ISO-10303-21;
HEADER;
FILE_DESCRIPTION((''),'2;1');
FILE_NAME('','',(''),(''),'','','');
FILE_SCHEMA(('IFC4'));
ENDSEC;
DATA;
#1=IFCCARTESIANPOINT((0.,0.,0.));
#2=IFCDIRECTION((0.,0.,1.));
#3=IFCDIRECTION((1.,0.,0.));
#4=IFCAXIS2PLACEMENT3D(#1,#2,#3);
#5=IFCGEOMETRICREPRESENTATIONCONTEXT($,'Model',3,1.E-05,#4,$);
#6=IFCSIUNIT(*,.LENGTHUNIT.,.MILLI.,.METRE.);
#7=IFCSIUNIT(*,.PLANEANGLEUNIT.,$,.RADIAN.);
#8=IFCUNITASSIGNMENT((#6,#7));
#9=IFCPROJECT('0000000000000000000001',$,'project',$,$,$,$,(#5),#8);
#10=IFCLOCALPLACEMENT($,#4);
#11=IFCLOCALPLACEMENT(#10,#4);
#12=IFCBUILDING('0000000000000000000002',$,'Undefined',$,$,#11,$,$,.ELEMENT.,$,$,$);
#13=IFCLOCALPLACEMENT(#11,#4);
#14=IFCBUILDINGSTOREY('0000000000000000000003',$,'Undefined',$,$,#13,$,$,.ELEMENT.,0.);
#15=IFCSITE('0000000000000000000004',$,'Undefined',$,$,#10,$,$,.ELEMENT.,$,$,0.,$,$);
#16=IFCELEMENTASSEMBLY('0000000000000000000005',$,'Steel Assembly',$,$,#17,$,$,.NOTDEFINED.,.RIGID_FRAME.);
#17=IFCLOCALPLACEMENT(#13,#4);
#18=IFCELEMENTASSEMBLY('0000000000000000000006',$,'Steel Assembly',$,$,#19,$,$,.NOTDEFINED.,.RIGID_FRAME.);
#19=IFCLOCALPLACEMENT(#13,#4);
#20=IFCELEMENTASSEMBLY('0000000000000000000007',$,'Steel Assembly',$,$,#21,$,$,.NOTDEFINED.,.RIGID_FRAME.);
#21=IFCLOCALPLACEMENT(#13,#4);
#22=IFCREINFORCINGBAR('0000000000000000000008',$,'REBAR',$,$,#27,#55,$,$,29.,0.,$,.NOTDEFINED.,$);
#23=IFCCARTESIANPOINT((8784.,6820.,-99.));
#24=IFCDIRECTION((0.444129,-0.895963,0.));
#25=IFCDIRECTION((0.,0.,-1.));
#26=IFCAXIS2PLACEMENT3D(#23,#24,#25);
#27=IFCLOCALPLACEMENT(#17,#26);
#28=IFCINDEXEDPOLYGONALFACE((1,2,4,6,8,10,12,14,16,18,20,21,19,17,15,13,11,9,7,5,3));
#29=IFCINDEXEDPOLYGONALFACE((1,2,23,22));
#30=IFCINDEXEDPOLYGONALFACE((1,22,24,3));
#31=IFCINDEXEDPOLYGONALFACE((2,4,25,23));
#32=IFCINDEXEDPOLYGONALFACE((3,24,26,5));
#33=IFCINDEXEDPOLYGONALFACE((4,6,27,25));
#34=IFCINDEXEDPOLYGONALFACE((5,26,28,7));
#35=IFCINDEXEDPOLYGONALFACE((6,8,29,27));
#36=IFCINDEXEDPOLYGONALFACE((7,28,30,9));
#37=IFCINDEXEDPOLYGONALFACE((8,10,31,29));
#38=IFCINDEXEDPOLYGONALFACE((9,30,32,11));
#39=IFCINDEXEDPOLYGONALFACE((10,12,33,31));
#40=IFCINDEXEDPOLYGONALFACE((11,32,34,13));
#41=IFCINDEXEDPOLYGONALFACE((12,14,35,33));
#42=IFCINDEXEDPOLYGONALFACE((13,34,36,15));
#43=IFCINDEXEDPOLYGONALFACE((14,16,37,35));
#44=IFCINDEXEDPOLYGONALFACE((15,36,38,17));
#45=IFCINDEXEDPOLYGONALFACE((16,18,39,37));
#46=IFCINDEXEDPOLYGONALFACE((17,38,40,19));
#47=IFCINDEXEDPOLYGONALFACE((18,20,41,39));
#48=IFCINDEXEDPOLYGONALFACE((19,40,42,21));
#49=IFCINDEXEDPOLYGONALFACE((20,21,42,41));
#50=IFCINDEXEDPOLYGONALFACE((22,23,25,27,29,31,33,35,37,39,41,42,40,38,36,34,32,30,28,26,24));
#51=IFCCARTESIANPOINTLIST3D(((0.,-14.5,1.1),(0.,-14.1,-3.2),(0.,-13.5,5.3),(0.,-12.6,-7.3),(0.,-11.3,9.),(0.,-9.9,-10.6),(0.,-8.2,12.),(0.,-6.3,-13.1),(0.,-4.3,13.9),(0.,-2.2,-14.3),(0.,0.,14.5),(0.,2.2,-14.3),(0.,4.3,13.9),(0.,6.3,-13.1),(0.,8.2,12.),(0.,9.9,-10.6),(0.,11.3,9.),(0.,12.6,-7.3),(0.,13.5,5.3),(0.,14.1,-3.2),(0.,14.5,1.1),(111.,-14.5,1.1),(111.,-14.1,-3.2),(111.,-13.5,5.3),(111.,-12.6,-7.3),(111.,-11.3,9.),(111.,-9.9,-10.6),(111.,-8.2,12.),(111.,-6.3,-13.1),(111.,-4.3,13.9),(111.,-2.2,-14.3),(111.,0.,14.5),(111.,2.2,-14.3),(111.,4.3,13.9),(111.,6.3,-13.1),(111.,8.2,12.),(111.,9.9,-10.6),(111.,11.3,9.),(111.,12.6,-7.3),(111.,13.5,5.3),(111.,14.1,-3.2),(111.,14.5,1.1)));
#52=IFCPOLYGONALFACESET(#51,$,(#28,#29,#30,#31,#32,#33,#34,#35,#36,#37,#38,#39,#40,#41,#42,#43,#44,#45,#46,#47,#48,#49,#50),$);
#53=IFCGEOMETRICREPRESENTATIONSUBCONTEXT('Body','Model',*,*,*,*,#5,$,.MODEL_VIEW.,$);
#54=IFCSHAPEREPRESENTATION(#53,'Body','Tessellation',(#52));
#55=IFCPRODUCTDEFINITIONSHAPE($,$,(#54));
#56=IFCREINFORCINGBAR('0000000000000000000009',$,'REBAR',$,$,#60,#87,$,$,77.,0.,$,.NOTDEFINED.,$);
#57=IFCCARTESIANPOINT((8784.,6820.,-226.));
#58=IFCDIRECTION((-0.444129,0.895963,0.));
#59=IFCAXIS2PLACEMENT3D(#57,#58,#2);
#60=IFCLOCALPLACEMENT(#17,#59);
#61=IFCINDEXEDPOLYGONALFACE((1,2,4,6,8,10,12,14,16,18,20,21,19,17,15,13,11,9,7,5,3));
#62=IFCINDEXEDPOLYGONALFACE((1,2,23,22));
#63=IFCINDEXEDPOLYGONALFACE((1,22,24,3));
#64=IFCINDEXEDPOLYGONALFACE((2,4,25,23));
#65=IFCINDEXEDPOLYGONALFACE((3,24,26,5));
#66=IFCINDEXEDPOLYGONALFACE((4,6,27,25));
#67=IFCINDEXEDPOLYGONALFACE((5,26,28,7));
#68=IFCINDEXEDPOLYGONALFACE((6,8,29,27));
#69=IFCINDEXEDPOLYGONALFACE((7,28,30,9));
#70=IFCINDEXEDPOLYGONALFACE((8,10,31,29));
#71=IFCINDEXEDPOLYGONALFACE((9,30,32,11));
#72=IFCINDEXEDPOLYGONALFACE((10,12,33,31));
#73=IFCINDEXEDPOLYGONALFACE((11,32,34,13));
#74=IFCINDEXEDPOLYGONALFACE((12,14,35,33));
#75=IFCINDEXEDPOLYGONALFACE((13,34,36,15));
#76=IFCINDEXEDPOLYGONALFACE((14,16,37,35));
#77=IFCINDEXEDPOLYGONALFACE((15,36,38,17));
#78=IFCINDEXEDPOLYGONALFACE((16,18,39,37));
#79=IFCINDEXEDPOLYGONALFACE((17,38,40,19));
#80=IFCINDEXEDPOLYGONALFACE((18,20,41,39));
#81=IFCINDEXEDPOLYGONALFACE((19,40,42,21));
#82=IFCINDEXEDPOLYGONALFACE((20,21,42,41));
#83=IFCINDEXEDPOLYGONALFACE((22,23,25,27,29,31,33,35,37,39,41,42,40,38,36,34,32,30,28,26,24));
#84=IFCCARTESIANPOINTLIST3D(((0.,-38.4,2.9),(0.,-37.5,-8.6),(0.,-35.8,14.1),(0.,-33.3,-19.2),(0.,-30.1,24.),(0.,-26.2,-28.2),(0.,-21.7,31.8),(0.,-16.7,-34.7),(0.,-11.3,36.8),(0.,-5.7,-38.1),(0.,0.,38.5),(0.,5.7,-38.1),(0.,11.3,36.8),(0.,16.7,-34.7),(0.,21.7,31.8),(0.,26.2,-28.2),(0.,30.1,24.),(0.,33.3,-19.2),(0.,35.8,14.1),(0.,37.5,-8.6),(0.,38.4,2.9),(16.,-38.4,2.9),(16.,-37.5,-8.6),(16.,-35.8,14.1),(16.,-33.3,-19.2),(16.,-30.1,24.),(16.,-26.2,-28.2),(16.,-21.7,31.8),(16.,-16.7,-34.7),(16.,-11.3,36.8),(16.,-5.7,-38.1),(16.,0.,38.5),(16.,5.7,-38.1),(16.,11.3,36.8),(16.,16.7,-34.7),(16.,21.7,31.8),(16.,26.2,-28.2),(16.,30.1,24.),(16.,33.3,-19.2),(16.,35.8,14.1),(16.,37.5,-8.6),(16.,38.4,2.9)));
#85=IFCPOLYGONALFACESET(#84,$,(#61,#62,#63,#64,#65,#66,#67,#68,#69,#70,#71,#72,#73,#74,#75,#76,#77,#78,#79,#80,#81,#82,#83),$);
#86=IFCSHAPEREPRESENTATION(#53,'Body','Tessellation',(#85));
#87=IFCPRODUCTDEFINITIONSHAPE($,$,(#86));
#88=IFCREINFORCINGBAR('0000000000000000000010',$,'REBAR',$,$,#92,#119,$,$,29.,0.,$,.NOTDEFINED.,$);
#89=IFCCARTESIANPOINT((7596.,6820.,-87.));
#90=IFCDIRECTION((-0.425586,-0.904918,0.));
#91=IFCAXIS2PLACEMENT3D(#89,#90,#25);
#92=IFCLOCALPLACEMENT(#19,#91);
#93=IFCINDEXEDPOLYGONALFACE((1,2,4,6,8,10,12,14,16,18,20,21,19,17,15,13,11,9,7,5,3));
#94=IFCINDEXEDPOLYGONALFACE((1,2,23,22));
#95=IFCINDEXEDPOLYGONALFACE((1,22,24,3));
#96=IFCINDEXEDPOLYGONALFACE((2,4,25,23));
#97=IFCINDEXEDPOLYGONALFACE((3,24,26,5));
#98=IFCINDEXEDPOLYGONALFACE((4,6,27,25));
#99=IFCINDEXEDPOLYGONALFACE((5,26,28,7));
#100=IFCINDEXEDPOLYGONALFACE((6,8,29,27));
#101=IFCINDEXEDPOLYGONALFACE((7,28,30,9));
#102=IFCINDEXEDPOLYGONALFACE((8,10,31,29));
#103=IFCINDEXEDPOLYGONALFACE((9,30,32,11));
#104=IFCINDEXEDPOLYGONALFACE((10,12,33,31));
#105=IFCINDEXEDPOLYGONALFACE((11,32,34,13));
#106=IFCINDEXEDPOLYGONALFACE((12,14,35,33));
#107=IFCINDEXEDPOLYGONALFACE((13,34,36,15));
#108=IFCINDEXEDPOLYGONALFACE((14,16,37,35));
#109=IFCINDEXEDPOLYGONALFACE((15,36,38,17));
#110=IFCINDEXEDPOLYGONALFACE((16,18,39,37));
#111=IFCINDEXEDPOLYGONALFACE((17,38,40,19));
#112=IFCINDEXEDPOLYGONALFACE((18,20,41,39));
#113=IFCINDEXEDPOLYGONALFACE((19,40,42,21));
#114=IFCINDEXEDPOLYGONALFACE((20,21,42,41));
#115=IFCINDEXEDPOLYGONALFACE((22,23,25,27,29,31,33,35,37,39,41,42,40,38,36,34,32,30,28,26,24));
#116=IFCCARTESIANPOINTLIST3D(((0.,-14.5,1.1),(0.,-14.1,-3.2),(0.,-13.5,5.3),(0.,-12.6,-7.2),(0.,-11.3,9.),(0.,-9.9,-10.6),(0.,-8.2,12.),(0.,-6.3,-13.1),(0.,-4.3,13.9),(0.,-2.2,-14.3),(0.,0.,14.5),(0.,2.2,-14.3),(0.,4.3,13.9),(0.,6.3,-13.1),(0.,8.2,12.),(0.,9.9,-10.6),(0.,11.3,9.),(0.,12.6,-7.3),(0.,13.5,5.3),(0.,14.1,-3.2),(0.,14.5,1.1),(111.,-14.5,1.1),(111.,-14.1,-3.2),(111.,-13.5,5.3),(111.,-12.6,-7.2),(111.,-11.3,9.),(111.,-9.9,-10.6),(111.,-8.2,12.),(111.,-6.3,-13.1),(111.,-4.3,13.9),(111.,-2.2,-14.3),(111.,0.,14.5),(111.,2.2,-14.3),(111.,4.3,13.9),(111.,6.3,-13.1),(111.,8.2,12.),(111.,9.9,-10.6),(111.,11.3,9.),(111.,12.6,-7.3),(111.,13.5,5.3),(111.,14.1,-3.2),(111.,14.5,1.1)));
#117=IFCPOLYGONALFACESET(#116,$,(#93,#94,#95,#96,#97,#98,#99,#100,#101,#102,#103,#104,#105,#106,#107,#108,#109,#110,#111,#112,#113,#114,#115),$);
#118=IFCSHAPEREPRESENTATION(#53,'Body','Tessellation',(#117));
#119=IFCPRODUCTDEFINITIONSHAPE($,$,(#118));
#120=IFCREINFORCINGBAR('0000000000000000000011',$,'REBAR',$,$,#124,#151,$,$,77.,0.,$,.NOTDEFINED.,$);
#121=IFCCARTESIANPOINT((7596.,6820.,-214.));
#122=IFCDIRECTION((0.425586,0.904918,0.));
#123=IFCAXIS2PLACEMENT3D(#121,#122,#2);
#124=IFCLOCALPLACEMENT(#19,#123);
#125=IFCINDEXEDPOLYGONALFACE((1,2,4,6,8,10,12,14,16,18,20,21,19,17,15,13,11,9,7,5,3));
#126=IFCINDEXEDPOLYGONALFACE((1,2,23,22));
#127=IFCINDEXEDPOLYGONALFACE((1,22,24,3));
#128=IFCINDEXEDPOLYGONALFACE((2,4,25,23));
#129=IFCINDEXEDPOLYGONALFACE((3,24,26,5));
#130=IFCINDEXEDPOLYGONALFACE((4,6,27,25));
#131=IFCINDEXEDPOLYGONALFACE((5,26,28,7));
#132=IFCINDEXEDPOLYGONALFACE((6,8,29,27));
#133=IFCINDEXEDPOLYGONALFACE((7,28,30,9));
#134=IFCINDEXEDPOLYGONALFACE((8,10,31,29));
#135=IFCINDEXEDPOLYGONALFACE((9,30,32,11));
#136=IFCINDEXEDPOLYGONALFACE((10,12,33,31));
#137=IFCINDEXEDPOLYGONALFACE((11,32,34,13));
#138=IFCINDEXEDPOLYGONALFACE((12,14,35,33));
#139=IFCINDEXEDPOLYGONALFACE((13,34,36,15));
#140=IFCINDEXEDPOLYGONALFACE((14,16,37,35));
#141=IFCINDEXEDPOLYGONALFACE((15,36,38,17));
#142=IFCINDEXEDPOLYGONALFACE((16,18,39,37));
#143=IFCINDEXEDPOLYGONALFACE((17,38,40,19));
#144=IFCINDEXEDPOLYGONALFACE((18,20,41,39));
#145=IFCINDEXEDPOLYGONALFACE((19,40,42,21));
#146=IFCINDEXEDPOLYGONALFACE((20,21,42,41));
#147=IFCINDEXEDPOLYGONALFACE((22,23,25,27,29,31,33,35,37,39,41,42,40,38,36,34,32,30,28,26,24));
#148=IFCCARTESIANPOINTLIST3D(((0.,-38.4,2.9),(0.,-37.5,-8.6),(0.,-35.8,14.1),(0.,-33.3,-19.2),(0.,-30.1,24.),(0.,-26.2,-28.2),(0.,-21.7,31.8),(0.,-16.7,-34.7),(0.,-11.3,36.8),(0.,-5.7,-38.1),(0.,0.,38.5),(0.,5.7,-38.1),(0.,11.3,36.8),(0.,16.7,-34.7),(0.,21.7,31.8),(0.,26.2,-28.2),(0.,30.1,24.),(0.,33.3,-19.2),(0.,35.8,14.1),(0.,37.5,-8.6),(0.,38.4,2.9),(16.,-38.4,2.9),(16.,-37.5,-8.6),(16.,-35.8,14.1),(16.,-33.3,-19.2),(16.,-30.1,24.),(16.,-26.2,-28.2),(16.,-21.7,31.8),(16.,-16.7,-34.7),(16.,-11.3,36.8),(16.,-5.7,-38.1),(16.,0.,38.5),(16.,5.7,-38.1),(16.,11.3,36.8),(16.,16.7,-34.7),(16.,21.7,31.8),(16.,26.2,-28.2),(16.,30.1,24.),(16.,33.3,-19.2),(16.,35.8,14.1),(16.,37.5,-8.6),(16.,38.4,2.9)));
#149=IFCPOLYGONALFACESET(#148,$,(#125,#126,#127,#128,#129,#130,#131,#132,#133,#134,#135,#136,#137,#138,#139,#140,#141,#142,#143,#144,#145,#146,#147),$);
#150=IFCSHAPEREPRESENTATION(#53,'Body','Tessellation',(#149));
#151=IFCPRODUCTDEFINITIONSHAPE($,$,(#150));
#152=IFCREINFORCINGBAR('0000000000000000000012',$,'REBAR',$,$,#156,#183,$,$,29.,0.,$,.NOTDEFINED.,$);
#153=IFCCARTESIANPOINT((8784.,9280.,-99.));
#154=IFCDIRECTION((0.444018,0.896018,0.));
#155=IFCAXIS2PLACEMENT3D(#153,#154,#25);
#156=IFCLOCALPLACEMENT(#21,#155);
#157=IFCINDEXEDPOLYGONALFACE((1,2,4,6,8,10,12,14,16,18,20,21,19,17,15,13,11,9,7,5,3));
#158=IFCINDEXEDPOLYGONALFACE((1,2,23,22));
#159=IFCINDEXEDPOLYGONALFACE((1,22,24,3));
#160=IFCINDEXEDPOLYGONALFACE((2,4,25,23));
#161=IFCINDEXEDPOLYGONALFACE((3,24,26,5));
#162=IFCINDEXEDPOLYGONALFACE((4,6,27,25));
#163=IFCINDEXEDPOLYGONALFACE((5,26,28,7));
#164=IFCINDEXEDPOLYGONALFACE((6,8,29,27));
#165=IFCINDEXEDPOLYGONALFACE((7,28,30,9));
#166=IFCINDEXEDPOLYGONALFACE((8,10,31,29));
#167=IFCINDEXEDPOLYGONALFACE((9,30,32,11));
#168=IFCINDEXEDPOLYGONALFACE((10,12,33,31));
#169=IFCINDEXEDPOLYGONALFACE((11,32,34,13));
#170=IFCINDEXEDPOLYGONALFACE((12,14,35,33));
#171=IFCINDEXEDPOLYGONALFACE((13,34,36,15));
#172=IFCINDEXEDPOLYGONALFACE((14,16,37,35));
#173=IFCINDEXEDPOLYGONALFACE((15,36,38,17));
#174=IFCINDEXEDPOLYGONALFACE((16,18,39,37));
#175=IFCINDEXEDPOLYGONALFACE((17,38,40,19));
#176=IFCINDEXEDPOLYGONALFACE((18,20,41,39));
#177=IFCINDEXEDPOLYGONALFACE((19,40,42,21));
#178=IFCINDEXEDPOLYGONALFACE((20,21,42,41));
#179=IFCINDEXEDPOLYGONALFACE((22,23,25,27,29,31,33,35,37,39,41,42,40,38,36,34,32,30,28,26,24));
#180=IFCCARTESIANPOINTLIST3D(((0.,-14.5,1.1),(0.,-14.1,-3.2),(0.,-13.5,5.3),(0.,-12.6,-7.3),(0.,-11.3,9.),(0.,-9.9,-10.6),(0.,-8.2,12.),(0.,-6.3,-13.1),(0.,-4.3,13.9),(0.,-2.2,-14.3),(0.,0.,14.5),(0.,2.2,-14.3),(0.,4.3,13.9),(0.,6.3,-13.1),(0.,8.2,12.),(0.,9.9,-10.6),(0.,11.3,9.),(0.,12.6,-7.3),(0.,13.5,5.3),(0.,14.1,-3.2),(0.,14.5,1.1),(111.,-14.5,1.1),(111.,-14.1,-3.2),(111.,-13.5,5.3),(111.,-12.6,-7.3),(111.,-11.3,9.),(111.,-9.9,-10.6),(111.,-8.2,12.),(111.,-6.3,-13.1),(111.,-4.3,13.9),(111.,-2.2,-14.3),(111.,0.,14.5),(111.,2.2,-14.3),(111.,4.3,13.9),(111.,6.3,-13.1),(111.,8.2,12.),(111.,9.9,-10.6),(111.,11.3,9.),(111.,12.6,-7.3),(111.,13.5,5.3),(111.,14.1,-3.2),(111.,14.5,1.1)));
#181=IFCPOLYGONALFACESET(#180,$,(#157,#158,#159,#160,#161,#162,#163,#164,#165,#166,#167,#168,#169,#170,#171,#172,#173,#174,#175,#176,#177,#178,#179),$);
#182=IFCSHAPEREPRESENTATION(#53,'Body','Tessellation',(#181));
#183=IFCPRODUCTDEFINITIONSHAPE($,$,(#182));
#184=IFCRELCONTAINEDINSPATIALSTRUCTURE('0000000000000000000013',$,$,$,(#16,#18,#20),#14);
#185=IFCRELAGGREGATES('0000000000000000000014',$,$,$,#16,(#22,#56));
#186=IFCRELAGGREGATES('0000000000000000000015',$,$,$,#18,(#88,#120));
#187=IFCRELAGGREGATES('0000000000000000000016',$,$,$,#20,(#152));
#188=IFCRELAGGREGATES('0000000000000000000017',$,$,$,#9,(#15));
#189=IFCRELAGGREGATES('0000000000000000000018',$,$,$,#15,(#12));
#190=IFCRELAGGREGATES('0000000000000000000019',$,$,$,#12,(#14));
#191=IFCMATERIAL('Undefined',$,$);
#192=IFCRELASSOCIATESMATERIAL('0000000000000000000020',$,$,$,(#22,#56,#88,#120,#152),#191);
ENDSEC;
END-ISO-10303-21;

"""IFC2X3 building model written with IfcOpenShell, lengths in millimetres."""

from ifc_helpers import new_model, entity, si_unit, frame, origin_with_axes, place, context, subcontext, project, spatial, source, transform, mapped, material, element, aggregate, save


model = new_model("IFC2X3")

# Units and contexts
model_context = context("Model", 3, precision=1e-05, world=origin_with_axes())
body_context = subcontext(model_context, "Body", "Model", "MODEL_VIEW")
ifc_project = project(units=[si_unit("LENGTHUNIT", "METRE", prefix="MILLI"), si_unit("PLANEANGLEUNIT", "RADIAN")], contexts=[model_context])

# Site, building, storey
site_placement = place(None, origin_with_axes())
site = spatial("IfcSite", under=ifc_project, at=site_placement, Name="Undefined", CompositionType="ELEMENT", RefElevation=0.0)
building_placement = place(site_placement, origin_with_axes())
building = spatial("IfcBuilding", under=site, at=building_placement, Name="Undefined", CompositionType="ELEMENT")
storey_placement = place(building_placement, origin_with_axes())
storey = spatial("IfcBuildingStorey", under=building, at=storey_placement, Name="Undefined", CompositionType="ELEMENT", Elevation=0.0)

# Element assemblies
assembly_1_placement = place(storey_placement, origin_with_axes())
assembly_1 = element("IfcElementAssembly", 1, at=assembly_1_placement, inside=storey, Name="Steel Assembly", AssemblyPlace="NOTDEFINED", PredefinedType="RIGID_FRAME")
assembly_2_placement = place(storey_placement, origin_with_axes())
assembly_2 = element("IfcElementAssembly", 2, at=assembly_2_placement, inside=storey, Name="Steel Assembly", AssemblyPlace="NOTDEFINED", PredefinedType="RIGID_FRAME")
assembly_3_placement = place(storey_placement, origin_with_axes())
assembly_3 = element("IfcElementAssembly", 3, at=assembly_3_placement, inside=storey, Name="Steel Assembly", AssemblyPlace="NOTDEFINED", PredefinedType="RIGID_FRAME")

# Reinforcing bars
ifc_material_1 = material(Name="Undefined")
shared_shape_1 = source(origin_with_axes(), body_context, "Body", "AdvancedSweptSolid", [
    entity("IfcSweptDiskSolid", entity("IfcTrimmedCurve", entity("IfcLine", entity("IfcCartesianPoint", [0.0, 0.0, 0.0]), entity("IfcVector", entity("IfcDirection", [1.0, 0.0, 0.0]), 1.0)), [entity("IfcParameterValue", 0.0)], [entity("IfcParameterValue", 111.0)], True, "PARAMETER"), 14.5, None, 0.0, 111.0),
])
reinforcing_bar_1_placement = place(assembly_1_placement, frame((8784.0, 6820.0, -99.0), z_axis=(0.444129, -0.895963, 0.0), x_axis=(0.0, 0.0, -1.0)))
reinforcing_bar_1 = element("IfcReinforcingBar", 4, at=reinforcing_bar_1_placement, material=ifc_material_1, Name="REBAR", BarRole="NOTDEFINED", CrossSectionArea=0.0, NominalDiameter=29.0, context=body_context, shape_type="MappedRepresentation", body=[
    mapped(shared_shape_1, transform((0.0, 0.0, 0.0))),
])
shared_shape_2 = source(origin_with_axes(), body_context, "Body", "AdvancedSweptSolid", [
    entity("IfcSweptDiskSolid", entity("IfcTrimmedCurve", entity("IfcLine", entity("IfcCartesianPoint", [0.0, 0.0, 0.0]), entity("IfcVector", entity("IfcDirection", [1.0, 0.0, 0.0]), 1.0)), [entity("IfcParameterValue", 0.0)], [entity("IfcParameterValue", 16.0)], True, "PARAMETER"), 38.5, None, 0.0, 16.0),
])
reinforcing_bar_2_placement = place(assembly_1_placement, frame((8784.0, 6820.0, -226.0), z_axis=(-0.444129, 0.895963, 0.0), x_axis=(0.0, 0.0, 1.0)))
reinforcing_bar_2 = element("IfcReinforcingBar", 5, at=reinforcing_bar_2_placement, material=ifc_material_1, Name="REBAR", BarRole="NOTDEFINED", CrossSectionArea=0.0, NominalDiameter=77.0, context=body_context, shape_type="MappedRepresentation", body=[
    mapped(shared_shape_2, transform((0.0, 0.0, 0.0))),
])
aggregate(assembly_1, [reinforcing_bar_1, reinforcing_bar_2])
shared_shape_3 = source(origin_with_axes(), body_context, "Body", "AdvancedSweptSolid", [
    entity("IfcSweptDiskSolid", entity("IfcTrimmedCurve", entity("IfcLine", entity("IfcCartesianPoint", [0.0, 0.0, 0.0]), entity("IfcVector", entity("IfcDirection", [1.0, 0.0, 0.0]), 1.0)), [entity("IfcParameterValue", 0.0)], [entity("IfcParameterValue", 111.0)], True, "PARAMETER"), 14.5, None, 0.0, 111.0),
])
reinforcing_bar_3_placement = place(assembly_2_placement, frame((7596.0, 6820.0, -87.0), z_axis=(-0.425586, -0.904918, 0.0), x_axis=(0.0, 0.0, -1.0)))
reinforcing_bar_3 = element("IfcReinforcingBar", 6, at=reinforcing_bar_3_placement, material=ifc_material_1, Name="REBAR", BarRole="NOTDEFINED", CrossSectionArea=0.0, NominalDiameter=29.0, context=body_context, shape_type="MappedRepresentation", body=[
    mapped(shared_shape_3, transform((0.0, 0.0, 0.0))),
])
shared_shape_4 = source(origin_with_axes(), body_context, "Body", "AdvancedSweptSolid", [
    entity("IfcSweptDiskSolid", entity("IfcTrimmedCurve", entity("IfcLine", entity("IfcCartesianPoint", [0.0, 0.0, 0.0]), entity("IfcVector", entity("IfcDirection", [1.0, 0.0, 0.0]), 1.0)), [entity("IfcParameterValue", 0.0)], [entity("IfcParameterValue", 16.0)], True, "PARAMETER"), 38.5, None, 0.0, 16.0),
])
reinforcing_bar_4_placement = place(assembly_2_placement, frame((7596.0, 6820.0, -214.0), z_axis=(0.425586, 0.904918, 0.0), x_axis=(0.0, 0.0, 1.0)))
reinforcing_bar_4 = element("IfcReinforcingBar", 7, at=reinforcing_bar_4_placement, material=ifc_material_1, Name="REBAR", BarRole="NOTDEFINED", CrossSectionArea=0.0, NominalDiameter=77.0, context=body_context, shape_type="MappedRepresentation", body=[
    mapped(shared_shape_4, transform((0.0, 0.0, 0.0))),
])
aggregate(assembly_2, [reinforcing_bar_3, reinforcing_bar_4])
shared_shape_5 = source(origin_with_axes(), body_context, "Body", "AdvancedSweptSolid", [
    entity("IfcSweptDiskSolid", entity("IfcTrimmedCurve", entity("IfcLine", entity("IfcCartesianPoint", [0.0, 0.0, 0.0]), entity("IfcVector", entity("IfcDirection", [1.0, 0.0, 0.0]), 1.0)), [entity("IfcParameterValue", 0.0)], [entity("IfcParameterValue", 111.0)], True, "PARAMETER"), 14.5, None, 0.0, 111.0),
])
reinforcing_bar_5_placement = place(assembly_3_placement, frame((8784.0, 9280.0, -99.0), z_axis=(0.444018, 0.896018, 0.0), x_axis=(0.0, 0.0, -1.0)))
reinforcing_bar_5 = element("IfcReinforcingBar", 8, at=reinforcing_bar_5_placement, material=ifc_material_1, Name="REBAR", BarRole="NOTDEFINED", CrossSectionArea=0.0, NominalDiameter=29.0, context=body_context, shape_type="MappedRepresentation", body=[
    mapped(shared_shape_5, transform((0.0, 0.0, 0.0))),
])
aggregate(assembly_3, [reinforcing_bar_5])

save(model, "model.ifc")
